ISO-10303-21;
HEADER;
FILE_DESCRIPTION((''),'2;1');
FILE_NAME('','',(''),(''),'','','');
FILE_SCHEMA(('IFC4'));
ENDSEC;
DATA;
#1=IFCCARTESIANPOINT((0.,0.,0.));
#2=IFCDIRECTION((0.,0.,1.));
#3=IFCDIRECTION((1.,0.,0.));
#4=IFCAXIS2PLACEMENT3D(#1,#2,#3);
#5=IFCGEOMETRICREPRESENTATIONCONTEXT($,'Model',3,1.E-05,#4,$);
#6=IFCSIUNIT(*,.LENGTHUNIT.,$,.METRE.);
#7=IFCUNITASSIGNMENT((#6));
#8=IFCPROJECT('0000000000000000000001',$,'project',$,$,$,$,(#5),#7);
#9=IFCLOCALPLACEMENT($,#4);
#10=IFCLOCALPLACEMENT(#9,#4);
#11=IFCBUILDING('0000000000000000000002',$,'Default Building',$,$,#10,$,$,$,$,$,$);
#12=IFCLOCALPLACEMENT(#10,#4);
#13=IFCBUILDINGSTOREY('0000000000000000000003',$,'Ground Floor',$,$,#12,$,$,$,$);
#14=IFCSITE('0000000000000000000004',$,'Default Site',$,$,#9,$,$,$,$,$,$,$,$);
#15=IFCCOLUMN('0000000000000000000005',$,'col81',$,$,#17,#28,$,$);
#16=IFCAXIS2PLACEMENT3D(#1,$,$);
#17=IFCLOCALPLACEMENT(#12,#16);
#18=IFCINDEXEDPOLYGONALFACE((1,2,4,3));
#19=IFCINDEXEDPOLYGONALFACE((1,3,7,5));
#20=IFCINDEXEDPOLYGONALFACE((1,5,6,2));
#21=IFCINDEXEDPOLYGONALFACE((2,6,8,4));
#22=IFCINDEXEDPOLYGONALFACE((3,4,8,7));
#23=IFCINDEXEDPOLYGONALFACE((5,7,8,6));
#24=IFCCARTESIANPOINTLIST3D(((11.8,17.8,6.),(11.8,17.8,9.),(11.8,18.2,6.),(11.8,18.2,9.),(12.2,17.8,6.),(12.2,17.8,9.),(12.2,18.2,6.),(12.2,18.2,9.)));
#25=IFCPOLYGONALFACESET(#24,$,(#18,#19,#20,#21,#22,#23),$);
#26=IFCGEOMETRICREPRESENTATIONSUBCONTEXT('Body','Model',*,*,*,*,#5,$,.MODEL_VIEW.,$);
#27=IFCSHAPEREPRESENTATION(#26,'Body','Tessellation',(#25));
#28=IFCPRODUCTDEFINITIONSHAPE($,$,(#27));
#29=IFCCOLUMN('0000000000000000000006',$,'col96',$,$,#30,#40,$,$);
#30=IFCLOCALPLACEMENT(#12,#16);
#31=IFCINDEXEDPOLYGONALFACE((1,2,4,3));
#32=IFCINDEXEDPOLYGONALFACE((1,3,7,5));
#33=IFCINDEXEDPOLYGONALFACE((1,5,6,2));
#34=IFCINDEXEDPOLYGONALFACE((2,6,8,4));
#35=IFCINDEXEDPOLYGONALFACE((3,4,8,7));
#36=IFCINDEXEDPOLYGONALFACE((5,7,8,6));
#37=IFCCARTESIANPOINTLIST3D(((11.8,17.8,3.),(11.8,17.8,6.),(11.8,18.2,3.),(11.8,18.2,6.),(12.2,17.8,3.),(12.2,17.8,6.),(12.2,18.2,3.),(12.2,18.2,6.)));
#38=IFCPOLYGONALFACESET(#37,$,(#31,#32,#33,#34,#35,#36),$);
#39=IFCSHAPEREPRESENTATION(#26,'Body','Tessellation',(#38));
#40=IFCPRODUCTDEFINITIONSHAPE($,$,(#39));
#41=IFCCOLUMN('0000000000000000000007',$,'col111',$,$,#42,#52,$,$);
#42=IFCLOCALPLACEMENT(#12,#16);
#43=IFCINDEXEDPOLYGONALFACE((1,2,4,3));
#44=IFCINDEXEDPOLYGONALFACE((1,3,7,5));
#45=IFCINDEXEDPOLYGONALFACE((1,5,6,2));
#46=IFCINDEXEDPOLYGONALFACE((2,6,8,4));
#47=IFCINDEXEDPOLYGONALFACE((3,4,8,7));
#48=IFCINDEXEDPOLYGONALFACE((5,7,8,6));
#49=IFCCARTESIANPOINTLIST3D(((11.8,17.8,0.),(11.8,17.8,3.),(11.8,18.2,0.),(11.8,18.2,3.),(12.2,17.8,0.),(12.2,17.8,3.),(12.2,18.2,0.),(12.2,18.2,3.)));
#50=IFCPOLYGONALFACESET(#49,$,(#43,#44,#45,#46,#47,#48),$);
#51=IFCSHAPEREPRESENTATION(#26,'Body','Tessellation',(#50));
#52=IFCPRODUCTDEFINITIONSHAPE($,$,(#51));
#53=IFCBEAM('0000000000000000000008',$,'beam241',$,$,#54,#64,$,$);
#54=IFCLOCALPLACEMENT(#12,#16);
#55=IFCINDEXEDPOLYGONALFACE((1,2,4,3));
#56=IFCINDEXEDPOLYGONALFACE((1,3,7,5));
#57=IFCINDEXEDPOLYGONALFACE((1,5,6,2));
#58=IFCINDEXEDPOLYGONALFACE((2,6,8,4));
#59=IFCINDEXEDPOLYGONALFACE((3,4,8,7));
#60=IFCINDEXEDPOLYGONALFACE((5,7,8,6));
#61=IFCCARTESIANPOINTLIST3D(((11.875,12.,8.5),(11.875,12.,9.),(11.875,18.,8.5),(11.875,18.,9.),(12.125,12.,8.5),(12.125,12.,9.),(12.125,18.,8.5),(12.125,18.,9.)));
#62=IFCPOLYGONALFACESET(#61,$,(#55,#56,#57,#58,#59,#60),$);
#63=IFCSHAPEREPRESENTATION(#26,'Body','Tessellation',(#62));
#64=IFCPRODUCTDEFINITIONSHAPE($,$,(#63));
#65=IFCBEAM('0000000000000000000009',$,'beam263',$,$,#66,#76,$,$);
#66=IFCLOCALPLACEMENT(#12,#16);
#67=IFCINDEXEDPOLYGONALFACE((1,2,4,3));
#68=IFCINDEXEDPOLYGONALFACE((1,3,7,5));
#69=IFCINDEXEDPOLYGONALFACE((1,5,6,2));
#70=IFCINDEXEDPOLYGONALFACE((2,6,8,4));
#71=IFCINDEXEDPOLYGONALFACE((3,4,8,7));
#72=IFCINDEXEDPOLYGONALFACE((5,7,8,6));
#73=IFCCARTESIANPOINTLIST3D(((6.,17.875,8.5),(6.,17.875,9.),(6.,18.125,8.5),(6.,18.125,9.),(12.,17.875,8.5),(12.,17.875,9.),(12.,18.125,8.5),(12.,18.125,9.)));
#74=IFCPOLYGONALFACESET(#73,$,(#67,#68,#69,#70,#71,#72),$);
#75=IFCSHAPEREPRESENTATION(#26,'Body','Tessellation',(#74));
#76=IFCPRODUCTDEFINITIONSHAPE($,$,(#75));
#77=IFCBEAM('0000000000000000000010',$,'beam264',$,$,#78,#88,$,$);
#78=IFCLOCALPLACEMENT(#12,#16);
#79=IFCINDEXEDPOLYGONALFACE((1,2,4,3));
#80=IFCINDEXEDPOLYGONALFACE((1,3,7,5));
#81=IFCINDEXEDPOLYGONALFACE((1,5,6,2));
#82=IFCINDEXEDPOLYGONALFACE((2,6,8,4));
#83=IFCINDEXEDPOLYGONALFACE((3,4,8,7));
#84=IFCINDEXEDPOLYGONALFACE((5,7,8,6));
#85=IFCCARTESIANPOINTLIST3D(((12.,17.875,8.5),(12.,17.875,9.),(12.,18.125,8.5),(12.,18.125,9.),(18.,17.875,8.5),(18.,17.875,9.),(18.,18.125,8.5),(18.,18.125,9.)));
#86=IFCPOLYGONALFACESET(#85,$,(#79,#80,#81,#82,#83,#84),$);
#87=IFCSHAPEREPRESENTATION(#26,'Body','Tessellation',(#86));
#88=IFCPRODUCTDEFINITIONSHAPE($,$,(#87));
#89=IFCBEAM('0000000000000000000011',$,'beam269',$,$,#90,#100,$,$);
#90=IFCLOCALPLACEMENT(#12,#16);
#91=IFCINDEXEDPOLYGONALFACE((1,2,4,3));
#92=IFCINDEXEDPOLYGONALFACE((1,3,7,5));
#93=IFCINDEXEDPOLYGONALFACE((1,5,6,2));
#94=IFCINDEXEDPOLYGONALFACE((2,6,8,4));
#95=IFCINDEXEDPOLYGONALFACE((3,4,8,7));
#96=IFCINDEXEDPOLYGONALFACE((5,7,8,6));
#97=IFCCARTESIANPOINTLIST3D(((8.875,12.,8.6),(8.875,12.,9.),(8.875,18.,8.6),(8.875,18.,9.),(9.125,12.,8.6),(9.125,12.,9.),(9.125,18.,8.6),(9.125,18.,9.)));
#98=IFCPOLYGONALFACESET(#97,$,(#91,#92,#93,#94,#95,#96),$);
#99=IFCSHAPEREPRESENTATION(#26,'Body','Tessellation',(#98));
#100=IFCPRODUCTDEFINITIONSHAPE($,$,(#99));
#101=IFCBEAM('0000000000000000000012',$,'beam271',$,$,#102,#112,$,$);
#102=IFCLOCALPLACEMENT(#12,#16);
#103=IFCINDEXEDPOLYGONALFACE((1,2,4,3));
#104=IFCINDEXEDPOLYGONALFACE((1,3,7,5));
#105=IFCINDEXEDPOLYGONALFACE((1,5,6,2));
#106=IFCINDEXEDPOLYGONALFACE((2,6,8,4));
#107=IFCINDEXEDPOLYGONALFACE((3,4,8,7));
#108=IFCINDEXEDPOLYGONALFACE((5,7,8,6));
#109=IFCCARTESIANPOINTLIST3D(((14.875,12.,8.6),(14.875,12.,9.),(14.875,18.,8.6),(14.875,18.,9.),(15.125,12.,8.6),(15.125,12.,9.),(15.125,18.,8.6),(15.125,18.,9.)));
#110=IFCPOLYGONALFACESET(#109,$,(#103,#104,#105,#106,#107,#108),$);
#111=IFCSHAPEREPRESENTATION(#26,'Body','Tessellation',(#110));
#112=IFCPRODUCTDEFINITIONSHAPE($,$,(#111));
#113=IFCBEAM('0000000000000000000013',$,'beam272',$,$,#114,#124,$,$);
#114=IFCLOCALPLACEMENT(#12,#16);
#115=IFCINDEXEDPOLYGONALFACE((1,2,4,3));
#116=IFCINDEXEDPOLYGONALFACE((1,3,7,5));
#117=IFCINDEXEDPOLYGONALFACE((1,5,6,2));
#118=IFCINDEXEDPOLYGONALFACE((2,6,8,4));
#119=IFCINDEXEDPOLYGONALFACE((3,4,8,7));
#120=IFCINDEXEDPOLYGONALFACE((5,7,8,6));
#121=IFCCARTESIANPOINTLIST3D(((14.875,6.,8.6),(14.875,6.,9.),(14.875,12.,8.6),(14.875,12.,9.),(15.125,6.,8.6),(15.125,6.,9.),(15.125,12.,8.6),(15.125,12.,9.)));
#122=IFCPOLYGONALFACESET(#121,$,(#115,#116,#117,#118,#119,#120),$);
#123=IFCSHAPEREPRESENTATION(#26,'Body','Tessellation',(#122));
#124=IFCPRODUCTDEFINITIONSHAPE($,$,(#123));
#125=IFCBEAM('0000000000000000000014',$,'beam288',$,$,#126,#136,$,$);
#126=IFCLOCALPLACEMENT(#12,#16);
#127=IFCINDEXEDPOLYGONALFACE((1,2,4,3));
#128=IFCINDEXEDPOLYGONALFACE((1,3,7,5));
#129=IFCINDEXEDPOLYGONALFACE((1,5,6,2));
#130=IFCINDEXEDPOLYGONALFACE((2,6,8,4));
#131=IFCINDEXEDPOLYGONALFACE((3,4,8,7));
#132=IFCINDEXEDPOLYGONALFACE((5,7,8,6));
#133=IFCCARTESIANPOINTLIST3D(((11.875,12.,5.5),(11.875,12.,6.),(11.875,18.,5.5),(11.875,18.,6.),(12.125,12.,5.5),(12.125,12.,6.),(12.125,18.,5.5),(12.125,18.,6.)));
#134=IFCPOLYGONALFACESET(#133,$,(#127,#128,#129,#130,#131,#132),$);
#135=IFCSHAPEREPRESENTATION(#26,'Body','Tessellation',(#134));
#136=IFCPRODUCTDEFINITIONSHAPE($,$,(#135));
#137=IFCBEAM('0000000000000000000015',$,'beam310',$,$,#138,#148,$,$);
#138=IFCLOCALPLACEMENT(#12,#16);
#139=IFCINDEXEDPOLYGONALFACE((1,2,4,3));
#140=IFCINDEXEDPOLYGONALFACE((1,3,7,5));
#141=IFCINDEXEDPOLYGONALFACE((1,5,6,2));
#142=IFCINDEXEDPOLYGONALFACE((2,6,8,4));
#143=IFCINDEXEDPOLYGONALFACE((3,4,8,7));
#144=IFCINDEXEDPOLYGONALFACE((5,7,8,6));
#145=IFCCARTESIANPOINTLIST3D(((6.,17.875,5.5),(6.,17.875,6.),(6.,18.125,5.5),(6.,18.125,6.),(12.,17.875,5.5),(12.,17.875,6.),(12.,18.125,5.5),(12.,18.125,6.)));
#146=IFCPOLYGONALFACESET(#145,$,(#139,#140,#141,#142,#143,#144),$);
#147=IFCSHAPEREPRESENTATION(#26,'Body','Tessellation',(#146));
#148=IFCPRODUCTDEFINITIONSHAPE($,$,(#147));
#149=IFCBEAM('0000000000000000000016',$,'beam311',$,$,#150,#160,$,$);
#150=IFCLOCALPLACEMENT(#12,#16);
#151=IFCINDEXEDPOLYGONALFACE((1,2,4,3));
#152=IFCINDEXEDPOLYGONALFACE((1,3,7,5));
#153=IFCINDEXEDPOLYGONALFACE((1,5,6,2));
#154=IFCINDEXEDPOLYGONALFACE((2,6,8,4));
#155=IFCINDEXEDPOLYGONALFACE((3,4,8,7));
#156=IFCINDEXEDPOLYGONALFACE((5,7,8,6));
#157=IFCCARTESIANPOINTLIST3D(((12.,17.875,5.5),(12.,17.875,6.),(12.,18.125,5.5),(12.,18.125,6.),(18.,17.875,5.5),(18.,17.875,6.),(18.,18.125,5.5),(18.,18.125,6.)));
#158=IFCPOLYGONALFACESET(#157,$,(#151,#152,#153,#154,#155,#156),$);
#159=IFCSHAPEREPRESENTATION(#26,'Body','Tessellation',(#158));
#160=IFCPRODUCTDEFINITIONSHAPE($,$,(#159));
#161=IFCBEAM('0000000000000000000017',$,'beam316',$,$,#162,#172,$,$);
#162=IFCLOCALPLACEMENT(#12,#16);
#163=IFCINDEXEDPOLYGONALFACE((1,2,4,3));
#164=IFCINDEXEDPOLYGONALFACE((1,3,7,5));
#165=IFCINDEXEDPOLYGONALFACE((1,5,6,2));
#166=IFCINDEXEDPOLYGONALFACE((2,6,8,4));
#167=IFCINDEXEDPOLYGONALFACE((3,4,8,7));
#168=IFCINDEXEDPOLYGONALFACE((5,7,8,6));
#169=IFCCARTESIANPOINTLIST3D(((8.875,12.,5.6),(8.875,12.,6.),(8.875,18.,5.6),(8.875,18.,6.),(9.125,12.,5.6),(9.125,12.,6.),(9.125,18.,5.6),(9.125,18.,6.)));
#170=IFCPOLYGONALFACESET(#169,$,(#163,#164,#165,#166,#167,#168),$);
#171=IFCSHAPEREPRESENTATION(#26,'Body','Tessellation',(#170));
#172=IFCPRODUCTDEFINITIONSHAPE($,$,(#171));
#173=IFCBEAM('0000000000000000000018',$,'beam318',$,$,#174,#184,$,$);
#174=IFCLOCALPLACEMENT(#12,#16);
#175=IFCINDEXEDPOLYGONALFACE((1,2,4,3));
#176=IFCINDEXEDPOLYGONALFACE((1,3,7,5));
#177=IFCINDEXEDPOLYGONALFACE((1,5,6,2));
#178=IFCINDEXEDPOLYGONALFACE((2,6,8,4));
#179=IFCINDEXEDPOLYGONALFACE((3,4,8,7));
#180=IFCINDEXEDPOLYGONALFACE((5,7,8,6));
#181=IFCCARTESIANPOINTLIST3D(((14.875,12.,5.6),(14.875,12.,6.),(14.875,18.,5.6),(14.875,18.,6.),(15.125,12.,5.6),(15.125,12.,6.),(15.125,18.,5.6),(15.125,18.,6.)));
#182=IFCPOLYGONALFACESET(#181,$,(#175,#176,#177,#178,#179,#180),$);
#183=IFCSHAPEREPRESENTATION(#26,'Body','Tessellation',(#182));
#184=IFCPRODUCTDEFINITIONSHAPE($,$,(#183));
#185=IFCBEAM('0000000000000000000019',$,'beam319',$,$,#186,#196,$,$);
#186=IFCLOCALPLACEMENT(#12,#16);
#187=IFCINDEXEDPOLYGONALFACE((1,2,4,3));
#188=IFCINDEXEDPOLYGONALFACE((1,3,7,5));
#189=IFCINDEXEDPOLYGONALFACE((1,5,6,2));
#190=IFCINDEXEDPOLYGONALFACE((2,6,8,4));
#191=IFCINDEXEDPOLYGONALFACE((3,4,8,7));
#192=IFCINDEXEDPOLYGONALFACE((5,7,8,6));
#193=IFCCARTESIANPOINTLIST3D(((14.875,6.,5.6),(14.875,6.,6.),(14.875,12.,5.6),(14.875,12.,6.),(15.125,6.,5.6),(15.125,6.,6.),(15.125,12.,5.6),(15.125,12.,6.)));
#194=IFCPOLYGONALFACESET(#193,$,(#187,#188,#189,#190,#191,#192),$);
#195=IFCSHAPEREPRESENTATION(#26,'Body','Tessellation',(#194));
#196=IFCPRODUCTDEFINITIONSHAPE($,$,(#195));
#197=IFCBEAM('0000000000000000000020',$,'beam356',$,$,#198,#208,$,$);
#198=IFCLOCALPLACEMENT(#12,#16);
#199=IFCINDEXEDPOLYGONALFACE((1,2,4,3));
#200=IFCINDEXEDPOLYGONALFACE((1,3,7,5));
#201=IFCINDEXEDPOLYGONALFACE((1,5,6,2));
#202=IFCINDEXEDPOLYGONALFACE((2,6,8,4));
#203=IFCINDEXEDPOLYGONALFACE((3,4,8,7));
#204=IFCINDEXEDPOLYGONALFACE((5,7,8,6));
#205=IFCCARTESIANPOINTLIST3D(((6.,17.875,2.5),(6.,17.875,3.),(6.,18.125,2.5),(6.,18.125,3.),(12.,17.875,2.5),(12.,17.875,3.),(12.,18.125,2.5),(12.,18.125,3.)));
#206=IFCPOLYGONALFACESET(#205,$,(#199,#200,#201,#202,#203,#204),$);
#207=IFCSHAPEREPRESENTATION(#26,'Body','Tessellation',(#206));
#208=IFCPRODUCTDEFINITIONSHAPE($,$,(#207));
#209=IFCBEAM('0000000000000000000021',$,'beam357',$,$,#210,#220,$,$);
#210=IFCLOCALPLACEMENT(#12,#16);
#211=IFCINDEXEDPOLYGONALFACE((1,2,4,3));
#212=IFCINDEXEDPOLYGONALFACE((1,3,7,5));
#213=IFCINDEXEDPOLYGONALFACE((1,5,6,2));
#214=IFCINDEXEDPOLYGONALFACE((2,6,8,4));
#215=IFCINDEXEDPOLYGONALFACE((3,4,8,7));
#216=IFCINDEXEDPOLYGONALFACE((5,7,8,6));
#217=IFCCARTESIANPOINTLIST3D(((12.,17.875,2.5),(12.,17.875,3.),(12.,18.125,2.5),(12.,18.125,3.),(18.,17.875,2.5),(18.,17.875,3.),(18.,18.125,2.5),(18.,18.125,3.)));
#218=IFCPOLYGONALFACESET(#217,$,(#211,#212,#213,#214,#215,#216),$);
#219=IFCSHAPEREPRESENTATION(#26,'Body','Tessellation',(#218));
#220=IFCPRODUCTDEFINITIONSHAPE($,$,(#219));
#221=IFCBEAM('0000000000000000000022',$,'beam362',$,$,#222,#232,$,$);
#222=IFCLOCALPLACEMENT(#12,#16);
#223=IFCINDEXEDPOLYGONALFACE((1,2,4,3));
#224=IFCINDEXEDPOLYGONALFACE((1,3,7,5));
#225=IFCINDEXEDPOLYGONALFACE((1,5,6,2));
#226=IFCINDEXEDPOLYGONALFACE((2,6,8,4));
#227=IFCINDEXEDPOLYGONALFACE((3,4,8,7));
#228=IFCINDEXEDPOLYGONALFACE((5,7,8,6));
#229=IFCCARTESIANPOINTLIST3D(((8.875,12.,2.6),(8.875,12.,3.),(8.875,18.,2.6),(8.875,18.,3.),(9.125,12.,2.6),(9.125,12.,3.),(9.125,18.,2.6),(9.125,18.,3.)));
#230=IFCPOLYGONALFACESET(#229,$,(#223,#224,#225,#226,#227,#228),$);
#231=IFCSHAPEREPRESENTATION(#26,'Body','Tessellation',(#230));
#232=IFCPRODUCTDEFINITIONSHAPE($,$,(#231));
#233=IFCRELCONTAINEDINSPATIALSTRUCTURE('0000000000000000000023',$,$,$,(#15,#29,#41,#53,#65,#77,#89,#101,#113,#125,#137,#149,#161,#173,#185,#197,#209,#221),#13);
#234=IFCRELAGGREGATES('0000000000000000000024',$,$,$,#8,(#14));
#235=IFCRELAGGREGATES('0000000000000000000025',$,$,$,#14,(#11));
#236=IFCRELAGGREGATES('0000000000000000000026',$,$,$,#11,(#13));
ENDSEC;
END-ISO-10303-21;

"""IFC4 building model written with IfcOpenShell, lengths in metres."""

from ifc_helpers import new_model, si_unit, frame, origin_with_axes, place, context, subcontext, project, spatial, indexed_curve, outline, extrude, element, save


model = new_model("IFC4")

# Units and contexts
model_context = context("Model", 3, precision=1e-05, world=origin_with_axes())
body_context = subcontext(model_context, "Body", "Model", "MODEL_VIEW")
ifc_project = project(units=[si_unit("LENGTHUNIT", "METRE")], contexts=[model_context])

# Site, building, storey
site_placement = place(None, origin_with_axes())
site = spatial("IfcSite", under=ifc_project, at=site_placement, Name="Default Site")
building_placement = place(site_placement, origin_with_axes())
building = spatial("IfcBuilding", under=site, at=building_placement, Name="Default Building")
storey_placement = place(building_placement, origin_with_axes())
storey = spatial("IfcBuildingStorey", under=building, at=storey_placement, Name="Ground Floor")

# Columns
for number, where, z_axis, x_axis, name in (
    (1, (11.8, 17.8, 6.0), (0.0, 0.0, 1.0), (1.0, 0.0, 0.0), "col81"),
    (2, (11.8, 17.8, 3.0), (0.0, 0.0, 1.0), (1.0, 0.0, 0.0), "col96"),
    (3, (11.8, 17.8, 0.0), (0.0, 0.0, 1.0), (1.0, 0.0, 0.0), "col111"),
):
    element("IfcColumn", number, at=place(storey_placement, frame(where, z_axis=z_axis, x_axis=x_axis)), inside=storey, Name=name, context=body_context, shape_type="SweptSolid", body=[
        extrude(outline(indexed_curve([(0.0, 0.0), (0.0, 0.4), (0.4, 0.4), (0.4, 0.0), (0.0, 0.0)], self_intersect=False)), origin_with_axes(), (0.0, 0.0, 1.0), 3.0),
    ])

# Beams
for number, where, z_axis, x_axis, name in (
    (4, (12.125, 12.0, 8.5), (0.0, 0.0, 1.0), (0.0, 1.0, 0.0), "beam241"),
    (5, (6.0, 17.875, 8.5), (0.0, 0.0, 1.0), (1.0, 0.0, 0.0), "beam263"),
    (6, (12.0, 17.875, 8.5), (0.0, 0.0, 1.0), (1.0, 0.0, 0.0), "beam264"),
):
    element("IfcBeam", number, at=place(storey_placement, frame(where, z_axis=z_axis, x_axis=x_axis)), inside=storey, Name=name, context=body_context, shape_type="SweptSolid", body=[
        extrude(outline(indexed_curve([(0.0, 0.0), (0.0, 0.25), (6.0, 0.25), (6.0, 0.0), (0.0, 0.0)], self_intersect=False)), origin_with_axes(), (0.0, 0.0, 1.0), 0.5),
    ])
for number, where, z_axis, x_axis, name in (
    (7, (8.875, 18.0, 8.6), (0.0, 0.0, 1.0), (0.0, -1.0, 0.0), "beam269"),
    (8, (14.875, 18.0, 8.6), (0.0, 0.0, 1.0), (0.0, -1.0, 0.0), "beam271"),
    (9, (14.875, 12.0, 8.6), (0.0, 0.0, 1.0), (0.0, -1.0, 0.0), "beam272"),
):
    element("IfcBeam", number, at=place(storey_placement, frame(where, z_axis=z_axis, x_axis=x_axis)), inside=storey, Name=name, context=body_context, shape_type="SweptSolid", body=[
        extrude(outline(indexed_curve([(0.0, 0.0), (0.0, 0.25), (6.0, 0.25), (6.0, 0.0), (0.0, 0.0)], self_intersect=False)), origin_with_axes(), (0.0, 0.0, 1.0), 0.4),
    ])
for number, where, z_axis, x_axis, name in (
    (10, (12.125, 12.0, 5.5), (0.0, 0.0, 1.0), (0.0, 1.0, 0.0), "beam288"),
    (11, (6.0, 17.875, 5.5), (0.0, 0.0, 1.0), (1.0, 0.0, 0.0), "beam310"),
    (12, (12.0, 17.875, 5.5), (0.0, 0.0, 1.0), (1.0, 0.0, 0.0), "beam311"),
):
    element("IfcBeam", number, at=place(storey_placement, frame(where, z_axis=z_axis, x_axis=x_axis)), inside=storey, Name=name, context=body_context, shape_type="SweptSolid", body=[
        extrude(outline(indexed_curve([(0.0, 0.0), (0.0, 0.25), (6.0, 0.25), (6.0, 0.0), (0.0, 0.0)], self_intersect=False)), origin_with_axes(), (0.0, 0.0, 1.0), 0.5),
    ])
for number, where, z_axis, x_axis, name in (
    (13, (8.875, 18.0, 5.6), (0.0, 0.0, 1.0), (0.0, -1.0, 0.0), "beam316"),
    (14, (14.875, 18.0, 5.6), (0.0, 0.0, 1.0), (0.0, -1.0, 0.0), "beam318"),
    (15, (14.875, 12.0, 5.6), (0.0, 0.0, 1.0), (0.0, -1.0, 0.0), "beam319"),
):
    element("IfcBeam", number, at=place(storey_placement, frame(where, z_axis=z_axis, x_axis=x_axis)), inside=storey, Name=name, context=body_context, shape_type="SweptSolid", body=[
        extrude(outline(indexed_curve([(0.0, 0.0), (0.0, 0.25), (6.0, 0.25), (6.0, 0.0), (0.0, 0.0)], self_intersect=False)), origin_with_axes(), (0.0, 0.0, 1.0), 0.4),
    ])
for number, where, z_axis, x_axis, name in (
    (16, (6.0, 17.875, 2.5), (0.0, 0.0, 1.0), (1.0, 0.0, 0.0), "beam356"),
    (17, (12.0, 17.875, 2.5), (0.0, 0.0, 1.0), (1.0, 0.0, 0.0), "beam357"),
):
    element("IfcBeam", number, at=place(storey_placement, frame(where, z_axis=z_axis, x_axis=x_axis)), inside=storey, Name=name, context=body_context, shape_type="SweptSolid", body=[
        extrude(outline(indexed_curve([(0.0, 0.0), (0.0, 0.25), (6.0, 0.25), (6.0, 0.0), (0.0, 0.0)], self_intersect=False)), origin_with_axes(), (0.0, 0.0, 1.0), 0.5),
    ])
for number, where, z_axis, x_axis, name in (
    (18, (8.875, 18.0, 2.6), (0.0, 0.0, 1.0), (0.0, -1.0, 0.0), "beam362"),
):
    element("IfcBeam", number, at=place(storey_placement, frame(where, z_axis=z_axis, x_axis=x_axis)), inside=storey, Name=name, context=body_context, shape_type="SweptSolid", body=[
        extrude(outline(indexed_curve([(0.0, 0.0), (0.0, 0.25), (6.0, 0.25), (6.0, 0.0), (0.0, 0.0)], self_intersect=False)), origin_with_axes(), (0.0, 0.0, 1.0), 0.4),
    ])

save(model, "model.ifc")
